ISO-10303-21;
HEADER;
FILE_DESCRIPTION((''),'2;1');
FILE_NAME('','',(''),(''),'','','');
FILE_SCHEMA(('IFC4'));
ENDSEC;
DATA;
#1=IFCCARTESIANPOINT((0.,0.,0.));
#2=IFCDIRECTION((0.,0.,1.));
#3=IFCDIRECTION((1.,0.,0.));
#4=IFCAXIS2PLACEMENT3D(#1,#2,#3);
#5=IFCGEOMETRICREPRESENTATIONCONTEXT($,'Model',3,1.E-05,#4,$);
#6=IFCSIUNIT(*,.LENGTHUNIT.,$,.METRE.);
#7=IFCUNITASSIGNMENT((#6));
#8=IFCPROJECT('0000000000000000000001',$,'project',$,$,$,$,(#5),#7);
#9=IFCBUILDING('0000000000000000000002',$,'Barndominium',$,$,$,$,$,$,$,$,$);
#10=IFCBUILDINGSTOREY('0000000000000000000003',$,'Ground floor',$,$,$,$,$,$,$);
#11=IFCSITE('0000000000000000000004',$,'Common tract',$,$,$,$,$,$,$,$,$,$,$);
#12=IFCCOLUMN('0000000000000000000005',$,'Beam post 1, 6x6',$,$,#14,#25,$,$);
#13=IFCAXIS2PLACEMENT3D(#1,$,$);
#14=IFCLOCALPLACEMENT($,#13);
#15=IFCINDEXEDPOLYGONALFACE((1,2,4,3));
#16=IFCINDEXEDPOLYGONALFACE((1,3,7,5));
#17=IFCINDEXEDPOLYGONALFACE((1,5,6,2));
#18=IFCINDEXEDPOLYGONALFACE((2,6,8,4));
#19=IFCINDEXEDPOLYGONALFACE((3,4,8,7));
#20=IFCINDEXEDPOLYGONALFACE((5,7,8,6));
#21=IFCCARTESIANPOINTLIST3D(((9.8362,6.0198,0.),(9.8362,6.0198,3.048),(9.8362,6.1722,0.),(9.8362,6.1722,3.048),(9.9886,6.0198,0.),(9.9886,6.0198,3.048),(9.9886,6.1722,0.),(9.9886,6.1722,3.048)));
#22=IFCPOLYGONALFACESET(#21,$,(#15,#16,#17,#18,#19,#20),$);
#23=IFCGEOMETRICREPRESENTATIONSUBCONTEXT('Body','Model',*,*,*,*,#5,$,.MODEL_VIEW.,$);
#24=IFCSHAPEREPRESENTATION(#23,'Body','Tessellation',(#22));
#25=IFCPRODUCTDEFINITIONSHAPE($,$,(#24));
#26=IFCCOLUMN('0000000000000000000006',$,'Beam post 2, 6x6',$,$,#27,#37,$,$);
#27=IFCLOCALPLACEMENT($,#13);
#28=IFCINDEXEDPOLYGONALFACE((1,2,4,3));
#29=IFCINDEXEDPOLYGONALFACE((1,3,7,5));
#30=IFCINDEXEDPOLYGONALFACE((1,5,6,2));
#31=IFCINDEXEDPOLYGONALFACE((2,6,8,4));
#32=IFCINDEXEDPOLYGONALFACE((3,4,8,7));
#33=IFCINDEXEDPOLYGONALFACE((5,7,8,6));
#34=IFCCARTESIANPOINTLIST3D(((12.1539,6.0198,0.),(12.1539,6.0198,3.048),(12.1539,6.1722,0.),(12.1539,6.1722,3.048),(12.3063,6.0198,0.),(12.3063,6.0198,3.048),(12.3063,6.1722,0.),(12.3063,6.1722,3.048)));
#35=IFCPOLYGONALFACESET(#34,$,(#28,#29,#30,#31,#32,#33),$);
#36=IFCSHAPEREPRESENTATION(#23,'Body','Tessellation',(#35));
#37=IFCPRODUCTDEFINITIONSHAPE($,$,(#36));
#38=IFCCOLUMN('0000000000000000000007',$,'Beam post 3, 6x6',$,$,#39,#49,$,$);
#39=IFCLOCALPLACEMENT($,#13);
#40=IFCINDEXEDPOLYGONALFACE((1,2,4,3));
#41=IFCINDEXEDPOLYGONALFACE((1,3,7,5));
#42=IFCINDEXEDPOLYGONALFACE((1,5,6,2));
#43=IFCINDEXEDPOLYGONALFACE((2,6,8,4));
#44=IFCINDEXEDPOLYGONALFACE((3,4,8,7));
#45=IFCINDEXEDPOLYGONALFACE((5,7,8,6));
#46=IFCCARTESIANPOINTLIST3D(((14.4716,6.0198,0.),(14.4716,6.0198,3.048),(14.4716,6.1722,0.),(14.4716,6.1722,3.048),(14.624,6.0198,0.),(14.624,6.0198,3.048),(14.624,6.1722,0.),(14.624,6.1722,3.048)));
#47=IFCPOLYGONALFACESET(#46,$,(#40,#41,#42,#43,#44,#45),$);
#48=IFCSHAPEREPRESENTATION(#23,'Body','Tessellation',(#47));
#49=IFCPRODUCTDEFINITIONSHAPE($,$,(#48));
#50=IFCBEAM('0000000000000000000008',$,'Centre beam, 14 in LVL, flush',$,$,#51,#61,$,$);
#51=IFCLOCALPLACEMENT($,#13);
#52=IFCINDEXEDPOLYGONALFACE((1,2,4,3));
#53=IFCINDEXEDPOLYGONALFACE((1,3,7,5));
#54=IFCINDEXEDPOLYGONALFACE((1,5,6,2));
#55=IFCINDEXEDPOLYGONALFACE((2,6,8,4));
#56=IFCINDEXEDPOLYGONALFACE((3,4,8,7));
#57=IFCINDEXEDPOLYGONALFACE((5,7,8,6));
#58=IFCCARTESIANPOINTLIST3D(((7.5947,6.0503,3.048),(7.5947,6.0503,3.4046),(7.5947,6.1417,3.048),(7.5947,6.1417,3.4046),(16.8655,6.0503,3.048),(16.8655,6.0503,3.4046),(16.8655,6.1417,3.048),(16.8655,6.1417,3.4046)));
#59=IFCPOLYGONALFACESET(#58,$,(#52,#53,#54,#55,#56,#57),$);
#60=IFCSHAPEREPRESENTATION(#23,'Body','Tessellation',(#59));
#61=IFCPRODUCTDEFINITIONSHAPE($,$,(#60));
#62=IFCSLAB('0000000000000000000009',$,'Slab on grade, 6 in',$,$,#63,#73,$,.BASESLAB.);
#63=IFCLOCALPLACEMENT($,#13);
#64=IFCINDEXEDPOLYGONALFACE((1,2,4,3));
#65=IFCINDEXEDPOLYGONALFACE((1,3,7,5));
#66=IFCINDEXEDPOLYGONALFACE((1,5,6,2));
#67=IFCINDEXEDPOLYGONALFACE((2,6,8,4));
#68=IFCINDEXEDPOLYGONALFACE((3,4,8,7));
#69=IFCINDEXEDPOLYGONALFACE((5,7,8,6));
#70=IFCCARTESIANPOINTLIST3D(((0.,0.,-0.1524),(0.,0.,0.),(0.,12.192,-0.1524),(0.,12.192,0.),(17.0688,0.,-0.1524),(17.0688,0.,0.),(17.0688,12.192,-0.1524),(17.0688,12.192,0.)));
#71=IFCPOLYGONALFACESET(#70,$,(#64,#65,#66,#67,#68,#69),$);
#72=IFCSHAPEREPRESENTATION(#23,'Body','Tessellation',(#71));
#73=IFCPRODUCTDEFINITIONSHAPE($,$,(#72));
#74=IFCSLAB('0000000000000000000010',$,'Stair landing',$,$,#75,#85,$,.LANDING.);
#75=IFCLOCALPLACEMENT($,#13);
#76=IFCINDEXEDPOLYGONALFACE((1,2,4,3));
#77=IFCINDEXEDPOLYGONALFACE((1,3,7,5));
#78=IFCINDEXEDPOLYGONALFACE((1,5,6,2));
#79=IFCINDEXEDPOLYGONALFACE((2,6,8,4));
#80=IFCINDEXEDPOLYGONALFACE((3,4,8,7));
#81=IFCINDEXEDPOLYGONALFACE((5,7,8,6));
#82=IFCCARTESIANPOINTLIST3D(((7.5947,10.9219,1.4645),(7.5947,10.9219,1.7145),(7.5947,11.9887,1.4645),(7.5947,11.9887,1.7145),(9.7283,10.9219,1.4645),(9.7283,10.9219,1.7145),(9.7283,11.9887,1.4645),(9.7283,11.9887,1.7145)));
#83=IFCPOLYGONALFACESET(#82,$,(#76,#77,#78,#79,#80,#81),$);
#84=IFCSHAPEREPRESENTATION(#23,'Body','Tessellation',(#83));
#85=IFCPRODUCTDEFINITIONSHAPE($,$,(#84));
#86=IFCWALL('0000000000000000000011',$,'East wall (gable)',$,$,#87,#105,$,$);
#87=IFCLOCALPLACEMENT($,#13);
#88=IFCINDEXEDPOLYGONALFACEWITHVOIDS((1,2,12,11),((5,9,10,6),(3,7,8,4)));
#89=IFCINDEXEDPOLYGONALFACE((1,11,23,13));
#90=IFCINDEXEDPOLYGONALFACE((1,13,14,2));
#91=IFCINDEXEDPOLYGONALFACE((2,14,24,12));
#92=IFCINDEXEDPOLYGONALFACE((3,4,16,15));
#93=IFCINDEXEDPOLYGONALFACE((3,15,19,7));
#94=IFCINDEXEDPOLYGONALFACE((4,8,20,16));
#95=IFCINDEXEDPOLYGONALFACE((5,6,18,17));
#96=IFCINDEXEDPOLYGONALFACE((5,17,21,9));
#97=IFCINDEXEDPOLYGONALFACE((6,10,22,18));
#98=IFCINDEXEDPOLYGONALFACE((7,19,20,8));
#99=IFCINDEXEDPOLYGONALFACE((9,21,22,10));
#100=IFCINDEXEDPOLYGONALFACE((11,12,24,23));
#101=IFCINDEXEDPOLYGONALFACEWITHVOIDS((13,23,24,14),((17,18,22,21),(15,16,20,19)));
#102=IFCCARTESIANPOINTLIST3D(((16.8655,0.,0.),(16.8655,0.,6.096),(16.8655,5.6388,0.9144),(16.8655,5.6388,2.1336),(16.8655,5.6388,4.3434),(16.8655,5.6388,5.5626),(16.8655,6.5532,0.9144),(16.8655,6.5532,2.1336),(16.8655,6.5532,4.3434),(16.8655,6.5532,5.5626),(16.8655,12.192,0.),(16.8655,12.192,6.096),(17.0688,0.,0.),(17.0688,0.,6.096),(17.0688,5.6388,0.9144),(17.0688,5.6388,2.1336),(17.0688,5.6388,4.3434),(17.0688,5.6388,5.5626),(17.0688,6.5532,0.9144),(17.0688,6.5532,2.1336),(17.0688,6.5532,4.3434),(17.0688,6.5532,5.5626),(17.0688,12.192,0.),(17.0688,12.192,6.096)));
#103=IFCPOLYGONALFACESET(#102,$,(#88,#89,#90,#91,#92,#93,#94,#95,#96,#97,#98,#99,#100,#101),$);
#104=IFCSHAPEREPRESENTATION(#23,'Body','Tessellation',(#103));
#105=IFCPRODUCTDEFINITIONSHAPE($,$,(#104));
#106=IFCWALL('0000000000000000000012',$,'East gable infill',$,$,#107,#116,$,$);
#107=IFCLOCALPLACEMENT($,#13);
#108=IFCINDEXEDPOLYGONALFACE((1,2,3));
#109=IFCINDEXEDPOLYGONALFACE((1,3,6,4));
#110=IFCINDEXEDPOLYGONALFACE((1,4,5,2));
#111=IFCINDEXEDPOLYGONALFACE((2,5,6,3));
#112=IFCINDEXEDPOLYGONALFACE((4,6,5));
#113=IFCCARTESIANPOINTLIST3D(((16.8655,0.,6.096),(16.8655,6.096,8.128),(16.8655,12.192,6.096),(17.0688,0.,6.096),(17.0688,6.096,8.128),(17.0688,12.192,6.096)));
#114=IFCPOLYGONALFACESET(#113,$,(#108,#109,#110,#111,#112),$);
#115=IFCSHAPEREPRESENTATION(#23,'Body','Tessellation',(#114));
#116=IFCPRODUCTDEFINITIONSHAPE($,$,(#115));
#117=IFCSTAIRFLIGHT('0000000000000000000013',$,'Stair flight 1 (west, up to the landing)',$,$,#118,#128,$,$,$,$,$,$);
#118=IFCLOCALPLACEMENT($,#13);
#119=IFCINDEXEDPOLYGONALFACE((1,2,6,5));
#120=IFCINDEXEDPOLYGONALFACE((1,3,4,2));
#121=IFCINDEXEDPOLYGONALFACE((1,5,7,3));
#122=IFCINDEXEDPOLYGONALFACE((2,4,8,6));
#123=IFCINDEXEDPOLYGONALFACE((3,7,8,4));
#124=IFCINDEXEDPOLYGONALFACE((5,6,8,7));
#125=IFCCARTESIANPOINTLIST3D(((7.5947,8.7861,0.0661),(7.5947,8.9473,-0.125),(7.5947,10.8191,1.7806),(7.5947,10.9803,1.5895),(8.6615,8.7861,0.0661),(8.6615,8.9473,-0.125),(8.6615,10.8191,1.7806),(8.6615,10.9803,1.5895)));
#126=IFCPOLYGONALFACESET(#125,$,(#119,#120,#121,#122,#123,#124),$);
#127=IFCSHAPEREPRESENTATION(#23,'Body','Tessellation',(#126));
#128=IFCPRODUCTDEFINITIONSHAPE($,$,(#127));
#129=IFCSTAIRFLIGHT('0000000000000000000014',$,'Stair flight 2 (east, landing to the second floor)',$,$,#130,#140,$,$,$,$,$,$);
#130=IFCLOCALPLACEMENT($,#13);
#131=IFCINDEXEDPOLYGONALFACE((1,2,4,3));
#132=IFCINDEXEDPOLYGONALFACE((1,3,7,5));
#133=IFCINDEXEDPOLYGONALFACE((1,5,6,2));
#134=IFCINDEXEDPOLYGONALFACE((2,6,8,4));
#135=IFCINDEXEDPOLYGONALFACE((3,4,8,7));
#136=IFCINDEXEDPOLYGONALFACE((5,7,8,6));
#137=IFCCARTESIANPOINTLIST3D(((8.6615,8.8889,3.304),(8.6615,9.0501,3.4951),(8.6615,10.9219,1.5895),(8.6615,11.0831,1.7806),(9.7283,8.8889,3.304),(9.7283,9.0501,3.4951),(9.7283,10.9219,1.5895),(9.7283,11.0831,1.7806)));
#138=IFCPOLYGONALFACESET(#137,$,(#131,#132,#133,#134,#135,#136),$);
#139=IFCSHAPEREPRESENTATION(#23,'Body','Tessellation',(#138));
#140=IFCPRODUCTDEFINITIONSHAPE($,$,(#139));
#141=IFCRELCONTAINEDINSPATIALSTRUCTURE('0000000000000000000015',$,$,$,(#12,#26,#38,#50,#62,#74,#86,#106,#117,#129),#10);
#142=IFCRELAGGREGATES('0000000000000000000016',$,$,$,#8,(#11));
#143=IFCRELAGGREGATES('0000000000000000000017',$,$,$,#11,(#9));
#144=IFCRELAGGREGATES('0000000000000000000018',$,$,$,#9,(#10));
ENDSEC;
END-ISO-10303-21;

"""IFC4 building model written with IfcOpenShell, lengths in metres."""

from ifc_helpers import new_model, si_unit, frame, origin_with_axes, place, context, subcontext, project, spatial, polyline, indexed_curve, rectangle, outline, extrude, element, save


model = new_model("IFC4")

# Units and contexts
model_context = context("Model", 3, precision=1e-05, world=origin_with_axes())
body_context = subcontext(model_context, "Body", "Model", "MODEL_VIEW")
ifc_project = project(units=[si_unit("LENGTHUNIT", "METRE")], contexts=[model_context])

# Site, building, storey
site = spatial("IfcSite", under=ifc_project, Name="Common tract")
building = spatial("IfcBuilding", under=site, Name="Barndominium")
storey = spatial("IfcBuildingStorey", under=building, Name="Ground floor")

# Columns
for number, where, z_axis, x_axis, name in (
    (1, (9.9124, 6.096, 0.0), (0.0, 0.0, 1.0), (1.0, 0.0, 0.0), "Beam post 1, 6x6"),
    (2, (12.2301, 6.096, 0.0), (0.0, 0.0, 1.0), (1.0, 0.0, 0.0), "Beam post 2, 6x6"),
    (3, (14.5478, 6.096, 0.0), (0.0, 0.0, 1.0), (1.0, 0.0, 0.0), "Beam post 3, 6x6"),
):
    element("IfcColumn", number, at=place(None, frame(where, z_axis=z_axis, x_axis=x_axis)), inside=storey, Name=name, context=body_context, shape_type="SweptSolid", body=[
        extrude(rectangle(XDim=0.1524, YDim=0.1524), origin_with_axes(), (0.0, 0.0, 1.0), 3.048),
    ])

# Beam
beam_placement = place(None, frame((12.2301, 6.096, 3.048), z_axis=(0.0, 0.0, 1.0), x_axis=(1.0, 0.0, 0.0)))
element("IfcBeam", 4, at=beam_placement, inside=storey, Name="Centre beam, 14 in LVL, flush", context=body_context, shape_type="SweptSolid", body=[
    extrude(rectangle(XDim=9.2708, YDim=0.0914), origin_with_axes(), (0.0, 0.0, 1.0), 0.3566),
])

# Slabs
slab_1_placement = place(None, frame((8.5344, 6.096, -0.1524), z_axis=(0.0, 0.0, 1.0), x_axis=(1.0, 0.0, 0.0)))
element("IfcSlab", 5, at=slab_1_placement, inside=storey, Name="Slab on grade, 6 in", PredefinedType="BASESLAB", context=body_context, shape_type="SweptSolid", body=[
    extrude(rectangle(XDim=17.0688, YDim=12.192), origin_with_axes(), (0.0, 0.0, 1.0), 0.1524),
])
slab_2_placement = place(None, frame((8.6615, 11.4553, 1.4645), z_axis=(0.0, 0.0, 1.0), x_axis=(1.0, 0.0, 0.0)))
element("IfcSlab", 6, at=slab_2_placement, inside=storey, Name="Stair landing", PredefinedType="LANDING", context=body_context, shape_type="SweptSolid", body=[
    extrude(rectangle(XDim=2.1336, YDim=1.0668), origin_with_axes(), (0.0, 0.0, 1.0), 0.25),
])

# Wall, openings
wall_1_placement = place(None, frame((17.0688, 0.0, 0.0), z_axis=(0.0, 0.0, 1.0), x_axis=(0.0, 1.0, 0.0)))
wall_1 = element("IfcWall", 7, at=wall_1_placement, inside=storey, Name="East wall (gable)", context=body_context, shape_type="SweptSolid", body=[
    extrude(outline(indexed_curve([(0.0, 0.0), (0.0, 0.2033), (12.192, 0.2033), (12.192, 0.0), (0.0, 0.0)], self_intersect=False)), origin_with_axes(), (0.0, 0.0, 1.0), 6.096),
])
opening_1_placement = place(wall_1_placement, frame((6.096, 0.1017, 0.9144), z_axis=(0.0, 0.0, 1.0), x_axis=(0.0, -1.0, 0.0)))
element("IfcOpeningElement", 8, at=opening_1_placement, cuts=wall_1, context=body_context, shape_type="SweptSolid", body=[
    extrude(rectangle(XDim=0.3033, YDim=0.9144), origin_with_axes(), (0.0, 0.0, 1.0), 1.2192),
])
opening_2_placement = place(wall_1_placement, frame((6.096, 0.1017, 4.3434), z_axis=(0.0, 0.0, 1.0), x_axis=(0.0, -1.0, 0.0)))
element("IfcOpeningElement", 9, at=opening_2_placement, cuts=wall_1, context=body_context, shape_type="SweptSolid", body=[
    extrude(rectangle(XDim=0.3033, YDim=0.9144), origin_with_axes(), (0.0, 0.0, 1.0), 1.2192),
])

# Wall
wall_2_placement = place(None, frame((16.8655, 0.0, 0.0), z_axis=(1.0, 0.0, 0.0), x_axis=(0.0, 1.0, 0.0)))
element("IfcWall", 10, at=wall_2_placement, inside=storey, Name="East gable infill", context=body_context, shape_type="SweptSolid", body=[
    extrude(outline(polyline([(0.0, 6.096), (12.192, 6.096), (6.096, 8.128), (0.0, 6.096)])), origin_with_axes(), (0.0, 0.0, 1.0), 0.2033),
])

# Stair flights
for number, where, z_axis, x_axis, name in (
    (11, (8.1281, 9.9638, 0.7323), (0.0, -0.644683, 0.76445), (1.0, 0.0, 0.0), "Stair flight 1 (west, up to the landing)"),
    (12, (9.1949, 9.9054, 2.4468), (0.0, 0.644683, 0.76445), (1.0, 0.0, 0.0), "Stair flight 2 (east, landing to the second floor)"),
):
    element("IfcStairFlight", number, at=place(None, frame(where, z_axis=z_axis, x_axis=x_axis)), inside=storey, Name=name, context=body_context, shape_type="SweptSolid", body=[
        extrude(rectangle(XDim=1.0668, YDim=2.6594), origin_with_axes(), (0.0, 0.0, 1.0), 0.25),
    ])

save(model, "model.ifc")
